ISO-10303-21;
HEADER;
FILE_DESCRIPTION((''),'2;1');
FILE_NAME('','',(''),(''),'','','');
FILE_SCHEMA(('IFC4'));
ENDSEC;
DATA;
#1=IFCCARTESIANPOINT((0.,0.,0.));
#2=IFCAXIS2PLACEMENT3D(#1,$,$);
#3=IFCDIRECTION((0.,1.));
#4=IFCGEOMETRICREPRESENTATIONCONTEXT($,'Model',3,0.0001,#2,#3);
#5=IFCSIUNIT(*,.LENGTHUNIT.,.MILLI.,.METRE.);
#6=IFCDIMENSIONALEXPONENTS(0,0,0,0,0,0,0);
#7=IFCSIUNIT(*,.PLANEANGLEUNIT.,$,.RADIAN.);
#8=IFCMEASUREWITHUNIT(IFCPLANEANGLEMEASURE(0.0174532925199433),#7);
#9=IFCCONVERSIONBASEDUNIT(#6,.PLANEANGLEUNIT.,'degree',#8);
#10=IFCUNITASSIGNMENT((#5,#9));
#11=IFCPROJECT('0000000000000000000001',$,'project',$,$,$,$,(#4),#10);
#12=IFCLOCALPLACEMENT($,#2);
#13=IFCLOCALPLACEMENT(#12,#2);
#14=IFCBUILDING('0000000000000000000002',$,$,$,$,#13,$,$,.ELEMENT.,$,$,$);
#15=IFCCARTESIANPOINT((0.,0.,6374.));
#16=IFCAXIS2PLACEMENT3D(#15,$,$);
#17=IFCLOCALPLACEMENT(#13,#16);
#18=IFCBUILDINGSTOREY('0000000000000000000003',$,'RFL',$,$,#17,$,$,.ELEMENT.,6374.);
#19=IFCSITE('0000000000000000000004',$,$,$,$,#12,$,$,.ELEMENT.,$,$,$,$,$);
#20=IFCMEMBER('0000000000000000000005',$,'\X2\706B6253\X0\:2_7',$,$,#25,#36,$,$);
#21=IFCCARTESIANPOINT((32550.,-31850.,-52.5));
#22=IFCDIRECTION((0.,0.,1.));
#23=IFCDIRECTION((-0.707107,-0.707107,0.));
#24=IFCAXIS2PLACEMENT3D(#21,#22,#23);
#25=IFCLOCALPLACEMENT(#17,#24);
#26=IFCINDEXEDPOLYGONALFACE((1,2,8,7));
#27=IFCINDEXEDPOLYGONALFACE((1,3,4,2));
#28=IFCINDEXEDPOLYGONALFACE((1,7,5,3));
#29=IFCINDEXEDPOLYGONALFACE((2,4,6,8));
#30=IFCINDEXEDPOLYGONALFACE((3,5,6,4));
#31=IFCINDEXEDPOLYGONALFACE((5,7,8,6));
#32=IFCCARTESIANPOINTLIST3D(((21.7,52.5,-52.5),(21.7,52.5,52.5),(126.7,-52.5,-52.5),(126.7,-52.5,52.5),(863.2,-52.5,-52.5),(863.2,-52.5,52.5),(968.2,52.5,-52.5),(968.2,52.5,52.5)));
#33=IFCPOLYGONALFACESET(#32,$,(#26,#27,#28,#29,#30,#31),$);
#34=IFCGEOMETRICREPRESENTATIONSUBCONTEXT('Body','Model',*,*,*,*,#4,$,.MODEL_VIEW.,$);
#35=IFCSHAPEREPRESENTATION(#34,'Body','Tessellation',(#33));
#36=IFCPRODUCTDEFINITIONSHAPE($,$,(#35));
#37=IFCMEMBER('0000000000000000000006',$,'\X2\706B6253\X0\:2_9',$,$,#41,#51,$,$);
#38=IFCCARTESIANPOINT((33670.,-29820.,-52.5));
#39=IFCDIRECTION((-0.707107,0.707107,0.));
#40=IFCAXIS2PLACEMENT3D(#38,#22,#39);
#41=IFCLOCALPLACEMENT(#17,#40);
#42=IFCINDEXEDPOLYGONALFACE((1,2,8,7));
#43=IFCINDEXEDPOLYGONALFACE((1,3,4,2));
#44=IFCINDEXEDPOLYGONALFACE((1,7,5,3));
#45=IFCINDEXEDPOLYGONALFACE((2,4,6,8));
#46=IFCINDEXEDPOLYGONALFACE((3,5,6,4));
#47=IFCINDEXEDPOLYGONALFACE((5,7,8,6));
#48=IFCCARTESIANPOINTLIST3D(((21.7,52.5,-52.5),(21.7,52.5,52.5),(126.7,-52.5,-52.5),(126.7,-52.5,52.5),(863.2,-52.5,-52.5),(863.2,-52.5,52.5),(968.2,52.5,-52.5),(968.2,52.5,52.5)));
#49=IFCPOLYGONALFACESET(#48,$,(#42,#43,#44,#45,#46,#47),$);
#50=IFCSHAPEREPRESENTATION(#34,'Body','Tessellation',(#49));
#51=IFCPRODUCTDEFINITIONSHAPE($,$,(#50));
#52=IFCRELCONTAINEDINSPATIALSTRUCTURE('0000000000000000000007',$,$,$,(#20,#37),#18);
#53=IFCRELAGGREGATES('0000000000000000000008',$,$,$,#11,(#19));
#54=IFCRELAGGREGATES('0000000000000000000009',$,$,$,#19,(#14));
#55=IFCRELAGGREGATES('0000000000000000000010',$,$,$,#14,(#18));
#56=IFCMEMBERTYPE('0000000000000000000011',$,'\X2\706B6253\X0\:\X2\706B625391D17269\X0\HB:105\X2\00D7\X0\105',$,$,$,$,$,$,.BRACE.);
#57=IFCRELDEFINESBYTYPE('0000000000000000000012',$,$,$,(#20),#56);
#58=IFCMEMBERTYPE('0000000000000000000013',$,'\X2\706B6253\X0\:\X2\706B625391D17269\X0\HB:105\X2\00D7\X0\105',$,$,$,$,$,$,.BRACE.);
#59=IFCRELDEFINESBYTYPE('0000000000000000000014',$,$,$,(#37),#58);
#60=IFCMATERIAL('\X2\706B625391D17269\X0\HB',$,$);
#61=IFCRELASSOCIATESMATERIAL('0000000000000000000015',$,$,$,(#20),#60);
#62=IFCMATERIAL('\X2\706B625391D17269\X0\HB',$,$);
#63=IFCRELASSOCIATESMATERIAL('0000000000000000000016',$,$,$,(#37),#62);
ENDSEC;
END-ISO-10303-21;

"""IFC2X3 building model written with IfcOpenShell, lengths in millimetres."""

from ifc_helpers import new_model, entity, si_unit, converted_unit, direction, frame, origin, place, context, subcontext, project, spatial, polyline, outline, extrude, material, type_object, element, save


model = new_model("IFC2X3")

# Units and contexts
model_context = context("Model", 3, precision=0.0001, world=origin(), true_north=direction((0.0, 1.0)))
body_context = subcontext(model_context, "Body", "Model", "MODEL_VIEW")
ifc_project = project(units=[si_unit("LENGTHUNIT", "METRE", prefix="MILLI"), converted_unit("PLANEANGLEUNIT", "degree", entity("IfcPlaneAngleMeasure", 0.0174532925199433), si_unit("PLANEANGLEUNIT", "RADIAN"), dimensions=[0, 0, 0, 0, 0, 0, 0])], contexts=[model_context])

# Site, building, storey
site_placement = place(None, origin())
site = spatial("IfcSite", under=ifc_project, at=site_placement, CompositionType="ELEMENT")
building_placement = place(site_placement, origin())
building = spatial("IfcBuilding", under=site, at=building_placement, CompositionType="ELEMENT")
storey_placement = place(building_placement, frame((0.0, 0.0, 6374.0)))
storey = spatial("IfcBuildingStorey", under=building, at=storey_placement, Name="RFL", CompositionType="ELEMENT", Elevation=6374.0)

# Members
ifc_material_1 = material(Name="火打金物HB")
member_type_1 = type_object("IfcMemberType", Name="火打:火打金物HB:105×105", PredefinedType="BRACE")
member_1_placement = place(storey_placement, frame((32550.0, -31850.0, -52.5), z_axis=(0.0, 0.0, 1.0), x_axis=(-0.707107, -0.707107, 0.0)))
element("IfcMember", 1, at=member_1_placement, inside=storey, type_object=member_type_1, material=ifc_material_1, Name="火打:2_7", context=body_context, shape_type="SweptSolid", body=[
    extrude(outline(polyline([(126.7, -52.5, 0.0), (21.7, 52.5, 0.0), (968.2, 52.5, 0.0), (863.2, -52.5, 0.0), (126.7, -52.5, 0.0)])), frame((0.0, 0.0, -52.5), z_axis=(0.0, 0.0, 1.0), x_axis=(1.0, 0.0, 0.0)), (0.0, 0.0, 1.0), 105.0),
])
ifc_material_2 = material(Name="火打金物HB")
member_type_2 = type_object("IfcMemberType", Name="火打:火打金物HB:105×105", PredefinedType="BRACE")
member_2_placement = place(storey_placement, frame((33670.0, -29820.0, -52.5), z_axis=(0.0, 0.0, 1.0), x_axis=(-0.707107, 0.707107, 0.0)))
element("IfcMember", 2, at=member_2_placement, inside=storey, type_object=member_type_2, material=ifc_material_2, Name="火打:2_9", context=body_context, shape_type="SweptSolid", body=[
    extrude(outline(polyline([(126.7, -52.5, 0.0), (21.7, 52.5, 0.0), (968.2, 52.5, 0.0), (863.2, -52.5, 0.0), (126.7, -52.5, 0.0)])), frame((0.0, 0.0, -52.5), z_axis=(0.0, 0.0, 1.0), x_axis=(1.0, 0.0, 0.0)), (0.0, 0.0, 1.0), 105.0),
])

save(model, "model.ifc")
